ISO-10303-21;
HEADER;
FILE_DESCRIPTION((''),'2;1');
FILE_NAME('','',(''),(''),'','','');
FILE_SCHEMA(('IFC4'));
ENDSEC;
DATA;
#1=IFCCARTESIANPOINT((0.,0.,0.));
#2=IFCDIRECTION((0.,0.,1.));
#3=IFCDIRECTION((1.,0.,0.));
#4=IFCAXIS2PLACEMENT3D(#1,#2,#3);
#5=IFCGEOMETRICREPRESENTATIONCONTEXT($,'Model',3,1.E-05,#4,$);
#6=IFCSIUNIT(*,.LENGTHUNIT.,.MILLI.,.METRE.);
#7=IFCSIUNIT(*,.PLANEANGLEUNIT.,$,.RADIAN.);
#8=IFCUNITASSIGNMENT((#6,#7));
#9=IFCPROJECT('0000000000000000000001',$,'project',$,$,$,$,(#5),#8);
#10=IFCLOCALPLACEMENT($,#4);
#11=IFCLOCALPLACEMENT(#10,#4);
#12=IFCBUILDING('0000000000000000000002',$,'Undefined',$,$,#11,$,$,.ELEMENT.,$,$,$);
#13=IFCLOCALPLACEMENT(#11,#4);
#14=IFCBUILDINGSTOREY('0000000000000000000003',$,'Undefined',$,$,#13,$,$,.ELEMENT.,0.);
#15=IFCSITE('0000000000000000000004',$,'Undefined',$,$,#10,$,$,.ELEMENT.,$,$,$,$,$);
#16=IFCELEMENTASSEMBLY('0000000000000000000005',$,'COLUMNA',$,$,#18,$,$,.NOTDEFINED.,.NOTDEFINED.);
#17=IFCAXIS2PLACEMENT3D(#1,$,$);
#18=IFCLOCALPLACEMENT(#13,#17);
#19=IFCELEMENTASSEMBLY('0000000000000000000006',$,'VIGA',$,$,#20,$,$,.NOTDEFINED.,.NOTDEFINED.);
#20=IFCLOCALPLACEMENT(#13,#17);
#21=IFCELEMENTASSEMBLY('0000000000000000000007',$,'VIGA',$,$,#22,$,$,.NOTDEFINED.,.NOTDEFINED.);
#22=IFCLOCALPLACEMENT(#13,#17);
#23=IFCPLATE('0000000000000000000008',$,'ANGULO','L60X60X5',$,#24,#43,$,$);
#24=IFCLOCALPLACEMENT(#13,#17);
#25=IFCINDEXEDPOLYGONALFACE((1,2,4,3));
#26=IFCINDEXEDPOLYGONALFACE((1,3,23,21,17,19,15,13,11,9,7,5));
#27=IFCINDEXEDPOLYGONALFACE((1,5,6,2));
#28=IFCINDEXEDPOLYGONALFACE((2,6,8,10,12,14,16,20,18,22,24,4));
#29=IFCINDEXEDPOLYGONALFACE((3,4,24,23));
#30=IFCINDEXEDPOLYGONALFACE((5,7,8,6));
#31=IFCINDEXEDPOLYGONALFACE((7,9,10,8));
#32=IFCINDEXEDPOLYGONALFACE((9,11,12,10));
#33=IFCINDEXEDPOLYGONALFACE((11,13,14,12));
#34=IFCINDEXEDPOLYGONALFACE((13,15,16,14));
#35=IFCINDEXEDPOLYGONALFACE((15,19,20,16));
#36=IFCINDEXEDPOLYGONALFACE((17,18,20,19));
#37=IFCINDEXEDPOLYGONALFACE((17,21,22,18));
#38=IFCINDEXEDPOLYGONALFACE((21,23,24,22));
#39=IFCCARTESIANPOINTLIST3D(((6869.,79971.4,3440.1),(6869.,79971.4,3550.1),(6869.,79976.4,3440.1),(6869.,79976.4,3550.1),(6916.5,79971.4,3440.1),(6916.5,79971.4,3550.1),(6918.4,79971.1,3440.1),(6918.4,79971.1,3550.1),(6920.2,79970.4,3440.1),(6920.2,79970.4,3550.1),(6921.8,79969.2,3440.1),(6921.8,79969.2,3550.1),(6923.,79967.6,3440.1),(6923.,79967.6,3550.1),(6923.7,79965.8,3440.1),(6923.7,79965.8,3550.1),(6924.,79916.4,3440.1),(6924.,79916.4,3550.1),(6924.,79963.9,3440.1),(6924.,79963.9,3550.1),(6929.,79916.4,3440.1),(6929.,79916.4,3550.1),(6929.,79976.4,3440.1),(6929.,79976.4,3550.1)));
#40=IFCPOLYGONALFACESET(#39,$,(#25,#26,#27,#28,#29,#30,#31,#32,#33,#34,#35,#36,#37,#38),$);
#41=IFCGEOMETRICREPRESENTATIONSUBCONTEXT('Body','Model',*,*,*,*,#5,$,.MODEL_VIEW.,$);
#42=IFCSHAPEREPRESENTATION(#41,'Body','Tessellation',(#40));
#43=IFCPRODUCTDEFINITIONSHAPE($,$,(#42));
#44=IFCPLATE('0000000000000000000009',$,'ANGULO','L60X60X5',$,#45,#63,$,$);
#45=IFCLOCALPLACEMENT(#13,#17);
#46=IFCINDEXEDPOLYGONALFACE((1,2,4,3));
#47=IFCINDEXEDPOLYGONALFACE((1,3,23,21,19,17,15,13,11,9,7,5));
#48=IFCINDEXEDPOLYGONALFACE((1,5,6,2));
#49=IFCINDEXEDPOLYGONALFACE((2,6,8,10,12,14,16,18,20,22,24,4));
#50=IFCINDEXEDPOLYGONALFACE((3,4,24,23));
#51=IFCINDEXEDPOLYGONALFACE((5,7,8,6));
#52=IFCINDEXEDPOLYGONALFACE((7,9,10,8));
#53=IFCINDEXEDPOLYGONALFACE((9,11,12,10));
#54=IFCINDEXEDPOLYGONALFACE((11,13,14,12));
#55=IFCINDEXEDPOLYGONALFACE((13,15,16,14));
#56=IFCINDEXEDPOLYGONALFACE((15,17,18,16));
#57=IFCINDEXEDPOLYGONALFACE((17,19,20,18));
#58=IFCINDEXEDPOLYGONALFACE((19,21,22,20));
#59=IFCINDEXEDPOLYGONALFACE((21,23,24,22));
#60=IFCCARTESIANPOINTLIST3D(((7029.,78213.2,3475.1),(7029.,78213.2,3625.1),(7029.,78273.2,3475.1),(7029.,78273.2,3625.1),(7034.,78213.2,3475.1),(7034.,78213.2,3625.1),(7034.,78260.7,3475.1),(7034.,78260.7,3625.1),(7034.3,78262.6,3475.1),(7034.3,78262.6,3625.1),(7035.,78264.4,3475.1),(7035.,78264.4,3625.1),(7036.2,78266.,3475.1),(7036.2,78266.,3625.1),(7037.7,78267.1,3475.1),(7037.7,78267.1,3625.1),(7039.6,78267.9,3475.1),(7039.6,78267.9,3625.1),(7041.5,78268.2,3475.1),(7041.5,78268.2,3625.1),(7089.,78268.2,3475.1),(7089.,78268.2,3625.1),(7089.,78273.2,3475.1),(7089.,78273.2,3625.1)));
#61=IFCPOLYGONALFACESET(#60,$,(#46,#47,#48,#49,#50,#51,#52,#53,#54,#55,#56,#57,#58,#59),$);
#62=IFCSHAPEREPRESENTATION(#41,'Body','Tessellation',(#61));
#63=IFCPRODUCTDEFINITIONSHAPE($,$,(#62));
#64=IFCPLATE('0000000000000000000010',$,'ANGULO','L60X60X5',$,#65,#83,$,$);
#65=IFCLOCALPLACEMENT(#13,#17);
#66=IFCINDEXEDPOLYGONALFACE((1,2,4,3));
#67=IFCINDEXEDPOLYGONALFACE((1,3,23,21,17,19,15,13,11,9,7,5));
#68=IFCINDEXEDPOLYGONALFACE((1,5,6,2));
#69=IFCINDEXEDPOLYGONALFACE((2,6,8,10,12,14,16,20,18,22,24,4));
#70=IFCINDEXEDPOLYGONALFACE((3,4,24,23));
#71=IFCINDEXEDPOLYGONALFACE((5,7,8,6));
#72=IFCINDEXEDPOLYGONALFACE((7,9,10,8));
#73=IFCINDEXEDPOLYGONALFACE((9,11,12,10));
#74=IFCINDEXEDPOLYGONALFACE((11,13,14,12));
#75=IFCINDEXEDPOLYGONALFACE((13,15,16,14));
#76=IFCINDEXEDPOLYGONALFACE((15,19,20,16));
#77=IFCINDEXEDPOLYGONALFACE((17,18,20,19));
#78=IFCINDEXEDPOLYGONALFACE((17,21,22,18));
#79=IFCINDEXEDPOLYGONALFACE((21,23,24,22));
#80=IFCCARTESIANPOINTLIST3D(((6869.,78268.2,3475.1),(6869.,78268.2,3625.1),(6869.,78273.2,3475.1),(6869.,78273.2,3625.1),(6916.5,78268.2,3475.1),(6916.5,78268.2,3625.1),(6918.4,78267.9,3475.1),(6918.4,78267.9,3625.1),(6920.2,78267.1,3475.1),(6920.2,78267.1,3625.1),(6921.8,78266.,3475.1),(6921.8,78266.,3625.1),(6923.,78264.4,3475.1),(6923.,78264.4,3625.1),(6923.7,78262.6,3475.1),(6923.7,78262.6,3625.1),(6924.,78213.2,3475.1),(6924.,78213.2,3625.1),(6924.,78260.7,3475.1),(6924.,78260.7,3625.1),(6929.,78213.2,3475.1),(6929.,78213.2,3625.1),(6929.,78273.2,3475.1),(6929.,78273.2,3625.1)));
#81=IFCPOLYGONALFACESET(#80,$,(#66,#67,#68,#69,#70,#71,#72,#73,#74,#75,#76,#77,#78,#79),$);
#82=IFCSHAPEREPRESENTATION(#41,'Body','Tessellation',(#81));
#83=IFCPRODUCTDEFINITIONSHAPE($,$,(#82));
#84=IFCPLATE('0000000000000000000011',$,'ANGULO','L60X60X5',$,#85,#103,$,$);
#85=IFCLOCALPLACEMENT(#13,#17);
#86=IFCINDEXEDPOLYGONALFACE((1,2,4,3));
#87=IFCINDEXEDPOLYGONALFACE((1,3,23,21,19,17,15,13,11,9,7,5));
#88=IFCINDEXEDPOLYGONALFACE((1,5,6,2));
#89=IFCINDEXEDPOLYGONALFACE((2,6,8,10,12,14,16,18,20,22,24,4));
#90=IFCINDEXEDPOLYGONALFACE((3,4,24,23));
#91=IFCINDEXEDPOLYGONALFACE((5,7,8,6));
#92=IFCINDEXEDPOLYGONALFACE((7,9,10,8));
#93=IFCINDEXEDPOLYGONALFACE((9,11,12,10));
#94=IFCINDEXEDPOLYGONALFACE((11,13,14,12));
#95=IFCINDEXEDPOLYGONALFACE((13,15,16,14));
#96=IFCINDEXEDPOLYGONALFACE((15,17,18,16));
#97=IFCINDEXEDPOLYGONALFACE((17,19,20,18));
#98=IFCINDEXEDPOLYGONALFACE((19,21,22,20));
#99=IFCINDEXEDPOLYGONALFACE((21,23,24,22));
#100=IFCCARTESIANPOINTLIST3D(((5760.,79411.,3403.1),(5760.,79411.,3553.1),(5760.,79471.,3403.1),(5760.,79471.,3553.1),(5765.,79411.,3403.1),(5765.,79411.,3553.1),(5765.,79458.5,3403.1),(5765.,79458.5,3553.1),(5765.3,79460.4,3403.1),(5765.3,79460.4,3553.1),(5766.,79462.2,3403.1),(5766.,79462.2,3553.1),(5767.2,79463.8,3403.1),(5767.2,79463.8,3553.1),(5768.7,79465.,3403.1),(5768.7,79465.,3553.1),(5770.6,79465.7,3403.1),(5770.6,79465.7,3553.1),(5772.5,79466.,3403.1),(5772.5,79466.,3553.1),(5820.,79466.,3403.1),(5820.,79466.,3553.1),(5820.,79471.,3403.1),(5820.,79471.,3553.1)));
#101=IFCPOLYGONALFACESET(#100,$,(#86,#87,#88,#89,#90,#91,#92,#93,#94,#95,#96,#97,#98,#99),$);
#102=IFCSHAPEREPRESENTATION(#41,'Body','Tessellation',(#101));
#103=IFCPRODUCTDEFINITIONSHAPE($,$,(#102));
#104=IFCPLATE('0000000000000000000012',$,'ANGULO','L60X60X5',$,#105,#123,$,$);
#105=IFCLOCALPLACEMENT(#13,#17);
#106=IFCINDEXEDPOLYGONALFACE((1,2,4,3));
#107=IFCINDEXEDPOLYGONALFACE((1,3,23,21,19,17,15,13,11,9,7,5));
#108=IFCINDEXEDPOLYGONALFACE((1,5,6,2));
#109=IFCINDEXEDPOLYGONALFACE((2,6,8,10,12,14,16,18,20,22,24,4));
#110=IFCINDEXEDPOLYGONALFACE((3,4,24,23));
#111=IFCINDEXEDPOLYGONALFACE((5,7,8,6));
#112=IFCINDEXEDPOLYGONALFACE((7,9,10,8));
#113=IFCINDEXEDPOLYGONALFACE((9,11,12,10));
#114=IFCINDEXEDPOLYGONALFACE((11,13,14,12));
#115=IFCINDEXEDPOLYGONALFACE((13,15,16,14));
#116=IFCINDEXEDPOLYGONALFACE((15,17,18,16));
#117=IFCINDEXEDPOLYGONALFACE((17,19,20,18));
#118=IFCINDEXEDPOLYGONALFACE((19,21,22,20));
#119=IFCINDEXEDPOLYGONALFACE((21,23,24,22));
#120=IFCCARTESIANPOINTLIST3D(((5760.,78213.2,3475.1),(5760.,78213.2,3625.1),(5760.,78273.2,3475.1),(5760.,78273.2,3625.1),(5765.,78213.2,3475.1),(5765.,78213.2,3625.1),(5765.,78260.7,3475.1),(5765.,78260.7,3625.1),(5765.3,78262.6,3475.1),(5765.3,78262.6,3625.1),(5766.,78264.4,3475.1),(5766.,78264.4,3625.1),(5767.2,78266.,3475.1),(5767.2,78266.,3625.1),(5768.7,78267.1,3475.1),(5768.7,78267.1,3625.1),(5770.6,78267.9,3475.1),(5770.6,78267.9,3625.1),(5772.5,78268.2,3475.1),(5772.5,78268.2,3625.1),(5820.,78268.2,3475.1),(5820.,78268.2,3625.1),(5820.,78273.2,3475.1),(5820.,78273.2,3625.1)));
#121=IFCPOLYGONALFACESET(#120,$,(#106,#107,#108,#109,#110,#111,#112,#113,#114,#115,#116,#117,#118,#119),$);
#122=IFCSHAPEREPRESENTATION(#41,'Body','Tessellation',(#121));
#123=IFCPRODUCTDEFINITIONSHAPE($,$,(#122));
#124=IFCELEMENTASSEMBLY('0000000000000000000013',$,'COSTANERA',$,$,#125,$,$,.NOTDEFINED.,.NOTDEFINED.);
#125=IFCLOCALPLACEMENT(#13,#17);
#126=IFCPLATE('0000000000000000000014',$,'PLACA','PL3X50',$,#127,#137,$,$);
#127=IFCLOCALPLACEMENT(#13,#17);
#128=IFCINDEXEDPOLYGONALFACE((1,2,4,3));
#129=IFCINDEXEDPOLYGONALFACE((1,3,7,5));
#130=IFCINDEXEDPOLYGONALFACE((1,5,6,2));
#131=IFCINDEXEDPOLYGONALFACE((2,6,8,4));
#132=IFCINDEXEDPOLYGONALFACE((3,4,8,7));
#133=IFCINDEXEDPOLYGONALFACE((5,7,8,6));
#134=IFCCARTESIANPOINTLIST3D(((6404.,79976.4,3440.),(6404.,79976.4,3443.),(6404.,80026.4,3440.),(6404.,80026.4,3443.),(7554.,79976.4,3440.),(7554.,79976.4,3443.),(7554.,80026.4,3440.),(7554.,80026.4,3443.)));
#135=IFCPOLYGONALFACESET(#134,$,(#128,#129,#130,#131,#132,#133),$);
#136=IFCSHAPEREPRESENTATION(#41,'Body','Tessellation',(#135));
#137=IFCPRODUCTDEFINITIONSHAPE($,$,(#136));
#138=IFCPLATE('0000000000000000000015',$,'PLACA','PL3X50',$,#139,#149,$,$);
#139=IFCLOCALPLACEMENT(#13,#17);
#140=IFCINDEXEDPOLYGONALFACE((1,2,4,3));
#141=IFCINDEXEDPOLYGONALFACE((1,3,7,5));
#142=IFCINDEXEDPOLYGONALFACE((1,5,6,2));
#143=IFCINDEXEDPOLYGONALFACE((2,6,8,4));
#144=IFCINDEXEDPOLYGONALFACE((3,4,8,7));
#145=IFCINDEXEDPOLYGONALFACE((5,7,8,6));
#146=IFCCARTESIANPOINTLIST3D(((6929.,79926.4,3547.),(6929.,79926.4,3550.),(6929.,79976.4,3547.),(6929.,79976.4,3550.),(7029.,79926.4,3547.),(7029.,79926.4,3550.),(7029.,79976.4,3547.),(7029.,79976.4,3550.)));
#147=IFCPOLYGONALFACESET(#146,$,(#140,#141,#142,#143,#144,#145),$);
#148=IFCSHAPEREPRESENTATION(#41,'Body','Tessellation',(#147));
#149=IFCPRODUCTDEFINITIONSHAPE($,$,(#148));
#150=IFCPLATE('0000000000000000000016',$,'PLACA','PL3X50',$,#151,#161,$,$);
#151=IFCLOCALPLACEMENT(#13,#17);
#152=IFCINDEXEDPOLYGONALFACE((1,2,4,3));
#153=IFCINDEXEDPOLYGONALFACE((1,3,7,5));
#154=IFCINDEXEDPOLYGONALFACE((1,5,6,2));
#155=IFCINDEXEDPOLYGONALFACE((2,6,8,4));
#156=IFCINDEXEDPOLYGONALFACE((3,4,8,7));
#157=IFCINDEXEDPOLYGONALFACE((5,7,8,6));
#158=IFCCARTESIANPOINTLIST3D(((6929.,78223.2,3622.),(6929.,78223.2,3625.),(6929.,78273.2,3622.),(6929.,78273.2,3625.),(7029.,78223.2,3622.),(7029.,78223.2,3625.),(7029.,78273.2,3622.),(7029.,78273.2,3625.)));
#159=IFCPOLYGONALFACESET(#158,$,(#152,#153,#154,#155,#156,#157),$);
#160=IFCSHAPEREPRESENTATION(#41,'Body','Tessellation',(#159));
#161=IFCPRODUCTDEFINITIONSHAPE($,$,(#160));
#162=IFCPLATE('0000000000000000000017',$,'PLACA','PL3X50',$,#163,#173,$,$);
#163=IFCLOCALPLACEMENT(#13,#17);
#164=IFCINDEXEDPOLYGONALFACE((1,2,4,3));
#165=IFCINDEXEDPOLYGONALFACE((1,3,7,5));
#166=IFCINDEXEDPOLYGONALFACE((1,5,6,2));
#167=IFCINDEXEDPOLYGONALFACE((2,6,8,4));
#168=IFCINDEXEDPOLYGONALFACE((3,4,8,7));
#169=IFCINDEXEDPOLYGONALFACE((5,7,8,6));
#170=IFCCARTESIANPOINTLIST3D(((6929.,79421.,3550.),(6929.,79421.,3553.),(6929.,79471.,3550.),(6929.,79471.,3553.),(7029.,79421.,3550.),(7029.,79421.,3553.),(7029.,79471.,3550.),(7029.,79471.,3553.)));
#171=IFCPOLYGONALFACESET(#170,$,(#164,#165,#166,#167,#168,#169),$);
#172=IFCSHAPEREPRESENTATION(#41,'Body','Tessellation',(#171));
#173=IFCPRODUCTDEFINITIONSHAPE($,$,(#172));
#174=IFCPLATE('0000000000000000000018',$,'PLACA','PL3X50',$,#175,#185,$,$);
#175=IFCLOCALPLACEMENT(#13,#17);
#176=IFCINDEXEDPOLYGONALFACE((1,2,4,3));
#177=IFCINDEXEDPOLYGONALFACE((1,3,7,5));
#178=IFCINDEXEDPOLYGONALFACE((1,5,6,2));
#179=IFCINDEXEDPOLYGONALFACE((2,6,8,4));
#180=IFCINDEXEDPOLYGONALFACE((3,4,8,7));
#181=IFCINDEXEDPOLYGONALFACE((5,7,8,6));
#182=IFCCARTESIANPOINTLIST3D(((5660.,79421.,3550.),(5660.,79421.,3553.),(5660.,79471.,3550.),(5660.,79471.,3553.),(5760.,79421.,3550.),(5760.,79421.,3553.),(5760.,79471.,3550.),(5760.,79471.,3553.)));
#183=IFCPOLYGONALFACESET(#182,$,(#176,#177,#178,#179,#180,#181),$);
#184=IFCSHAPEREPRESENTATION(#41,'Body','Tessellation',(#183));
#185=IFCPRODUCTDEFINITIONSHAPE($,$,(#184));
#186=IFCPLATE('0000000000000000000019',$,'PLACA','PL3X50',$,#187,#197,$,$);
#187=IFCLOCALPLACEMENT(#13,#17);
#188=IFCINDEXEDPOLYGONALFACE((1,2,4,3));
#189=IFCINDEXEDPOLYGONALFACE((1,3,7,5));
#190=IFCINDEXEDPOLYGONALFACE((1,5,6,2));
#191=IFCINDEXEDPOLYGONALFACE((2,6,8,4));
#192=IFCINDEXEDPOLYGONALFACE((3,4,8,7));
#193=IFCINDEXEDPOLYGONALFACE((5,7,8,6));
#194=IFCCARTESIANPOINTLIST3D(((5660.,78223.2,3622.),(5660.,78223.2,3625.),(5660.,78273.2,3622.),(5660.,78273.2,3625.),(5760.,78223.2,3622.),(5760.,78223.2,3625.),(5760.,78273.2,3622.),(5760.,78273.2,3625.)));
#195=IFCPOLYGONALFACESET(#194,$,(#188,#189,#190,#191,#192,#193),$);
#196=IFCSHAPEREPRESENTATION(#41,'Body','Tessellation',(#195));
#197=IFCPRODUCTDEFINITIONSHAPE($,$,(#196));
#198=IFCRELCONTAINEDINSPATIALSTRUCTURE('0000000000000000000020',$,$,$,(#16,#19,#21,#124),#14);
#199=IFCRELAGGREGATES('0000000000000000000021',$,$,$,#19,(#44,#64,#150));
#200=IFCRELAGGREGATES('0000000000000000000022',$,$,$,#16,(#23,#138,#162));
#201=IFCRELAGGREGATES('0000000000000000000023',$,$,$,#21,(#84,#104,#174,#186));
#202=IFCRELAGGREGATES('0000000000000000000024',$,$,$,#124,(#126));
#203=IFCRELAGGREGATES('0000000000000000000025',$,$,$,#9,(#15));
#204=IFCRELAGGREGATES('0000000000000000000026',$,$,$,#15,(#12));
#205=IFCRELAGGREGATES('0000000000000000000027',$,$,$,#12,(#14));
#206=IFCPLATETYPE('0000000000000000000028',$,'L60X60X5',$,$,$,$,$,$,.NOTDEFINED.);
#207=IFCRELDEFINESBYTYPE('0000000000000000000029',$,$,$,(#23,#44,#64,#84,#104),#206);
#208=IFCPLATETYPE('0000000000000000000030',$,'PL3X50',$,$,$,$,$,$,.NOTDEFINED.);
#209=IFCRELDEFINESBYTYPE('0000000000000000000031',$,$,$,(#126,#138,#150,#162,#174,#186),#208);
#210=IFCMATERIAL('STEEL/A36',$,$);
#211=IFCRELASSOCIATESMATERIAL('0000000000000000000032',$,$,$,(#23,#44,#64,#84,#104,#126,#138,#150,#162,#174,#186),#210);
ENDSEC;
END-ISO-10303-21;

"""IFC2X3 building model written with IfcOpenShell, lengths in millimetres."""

from ifc_helpers import new_model, si_unit, frame, origin_with_axes, origin_2d_with_axis, place, context, subcontext, project, spatial, polyline, l_section, outline, extrude, material, type_object, element, aggregate, save


model = new_model("IFC2X3")

# Units and contexts
model_context = context("Model", 3, precision=1e-05, world=origin_with_axes())
body_context = subcontext(model_context, "Body", "Model", "MODEL_VIEW")
ifc_project = project(units=[si_unit("LENGTHUNIT", "METRE", prefix="MILLI"), si_unit("PLANEANGLEUNIT", "RADIAN")], contexts=[model_context])

# Site, building, storey
site_placement = place(None, origin_with_axes())
site = spatial("IfcSite", under=ifc_project, at=site_placement, Name="Undefined", CompositionType="ELEMENT")
building_placement = place(site_placement, origin_with_axes())
building = spatial("IfcBuilding", under=site, at=building_placement, Name="Undefined", CompositionType="ELEMENT")
storey_placement = place(building_placement, origin_with_axes())
storey = spatial("IfcBuildingStorey", under=building, at=storey_placement, Name="Undefined", CompositionType="ELEMENT", Elevation=0.0)

# Element assemblies
assembly_1_placement = place(storey_placement, origin_with_axes())
assembly_1 = element("IfcElementAssembly", 1, at=assembly_1_placement, inside=storey, Name="COLUMNA", AssemblyPlace="NOTDEFINED", PredefinedType="NOTDEFINED")
ifc_material_1 = material(Name="STEEL/A36")
assembly_2_placement = place(storey_placement, origin_with_axes())
assembly_2 = element("IfcElementAssembly", 2, at=assembly_2_placement, inside=storey, Name="VIGA", AssemblyPlace="NOTDEFINED", PredefinedType="NOTDEFINED")

# Element assembly
assembly_3_placement = place(storey_placement, origin_with_axes())
assembly_3 = element("IfcElementAssembly", 3, at=assembly_3_placement, inside=storey, Name="VIGA", AssemblyPlace="NOTDEFINED", PredefinedType="NOTDEFINED")

# Plates
plate_type_1 = type_object("IfcPlateType", Name="L60X60X5", PredefinedType="NOTDEFINED")
plate_1_placement = place(assembly_1_placement, frame((6899.0, 79946.4, 3550.1), z_axis=(0.0, -1.0, 0.0), x_axis=(0.0, 0.0, -1.0)))
plate_1 = element("IfcPlate", 4, at=plate_1_placement, type_object=plate_type_1, material=ifc_material_1, Name="ANGULO", Description="L60X60X5", context=body_context, shape_type="SweptSolid", body=[
    extrude(l_section(Depth=60.0, Width=60.0, Thickness=5.0, FilletRadius=7.5, at=origin_2d_with_axis()), frame((110.0, 0.0, 0.0), z_axis=(-1.0, 0.0, 0.0), x_axis=(0.0, -1.0, 0.0)), (0.0, 0.0, 1.0), 110.0),
])
plate_2_placement = place(assembly_2_placement, frame((7059.0, 78243.2, 3475.1), z_axis=(0.0, -1.0, 0.0), x_axis=(0.0, 0.0, 1.0)))
plate_2 = element("IfcPlate", 5, at=plate_2_placement, type_object=plate_type_1, material=ifc_material_1, Name="ANGULO", Description="L60X60X5", context=body_context, shape_type="SweptSolid", body=[
    extrude(l_section(Depth=60.0, Width=60.0, Thickness=5.0, FilletRadius=7.5, at=origin_2d_with_axis()), frame((150.0, 0.0, 0.0), z_axis=(-1.0, 0.0, 0.0), x_axis=(0.0, -1.0, 0.0)), (0.0, 0.0, 1.0), 150.0),
])
plate_3_placement = place(assembly_2_placement, frame((6899.0, 78243.2, 3625.1), z_axis=(0.0, -1.0, 0.0), x_axis=(0.0, 0.0, -1.0)))
plate_3 = element("IfcPlate", 6, at=plate_3_placement, type_object=plate_type_1, material=ifc_material_1, Name="ANGULO", Description="L60X60X5", context=body_context, shape_type="SweptSolid", body=[
    extrude(l_section(Depth=60.0, Width=60.0, Thickness=5.0, FilletRadius=7.5, at=origin_2d_with_axis()), frame((150.0, 0.0, 0.0), z_axis=(-1.0, 0.0, 0.0), x_axis=(0.0, -1.0, 0.0)), (0.0, 0.0, 1.0), 150.0),
])
plate_4_placement = place(assembly_3_placement, frame((5790.0, 79441.0, 3403.1), z_axis=(0.0, -1.0, 0.0), x_axis=(0.0, 0.0, 1.0)))
plate_4 = element("IfcPlate", 7, at=plate_4_placement, type_object=plate_type_1, material=ifc_material_1, Name="ANGULO", Description="L60X60X5", context=body_context, shape_type="SweptSolid", body=[
    extrude(l_section(Depth=60.0, Width=60.0, Thickness=5.0, FilletRadius=7.5, at=origin_2d_with_axis()), frame((150.0, 0.0, 0.0), z_axis=(-1.0, 0.0, 0.0), x_axis=(0.0, -1.0, 0.0)), (0.0, 0.0, 1.0), 150.0),
])
plate_5_placement = place(assembly_3_placement, frame((5790.0, 78243.2, 3475.1), z_axis=(0.0, -1.0, 0.0), x_axis=(0.0, 0.0, 1.0)))
plate_5 = element("IfcPlate", 8, at=plate_5_placement, type_object=plate_type_1, material=ifc_material_1, Name="ANGULO", Description="L60X60X5", context=body_context, shape_type="SweptSolid", body=[
    extrude(l_section(Depth=60.0, Width=60.0, Thickness=5.0, FilletRadius=7.5, at=origin_2d_with_axis()), frame((150.0, 0.0, 0.0), z_axis=(-1.0, 0.0, 0.0), x_axis=(0.0, -1.0, 0.0)), (0.0, 0.0, 1.0), 150.0),
])

# Element assembly, plate
assembly_4_placement = place(storey_placement, origin_with_axes())
assembly_4 = element("IfcElementAssembly", 9, at=assembly_4_placement, inside=storey, Name="COSTANERA", AssemblyPlace="NOTDEFINED", PredefinedType="NOTDEFINED")
plate_type_2 = type_object("IfcPlateType", Name="PL3X50", PredefinedType="NOTDEFINED")
plate_6_placement = place(assembly_4_placement, frame((6404.0, 79976.4, 3441.5), z_axis=(0.0, 0.0, 1.0), x_axis=(1.0, 0.0, 0.0)))
plate_6 = element("IfcPlate", 10, at=plate_6_placement, type_object=plate_type_2, material=ifc_material_1, Name="PLACA", Description="PL3X50", context=body_context, shape_type="SweptSolid", body=[
    extrude(outline(polyline([(0.0, 0.0), (1150.0, 0.0), (1150.0, 50.0), (0.0, 50.0), (0.0, 0.0)])), frame((0.0, 0.0, -1.5), z_axis=(0.0, 0.0, 1.0), x_axis=(1.0, 0.0, 0.0)), (0.0, 0.0, 1.0), 3.0),
])

# Plates
plate_7_placement = place(assembly_1_placement, frame((6929.0, 79926.4, 3548.5), z_axis=(0.0, 0.0, -1.0), x_axis=(0.0, 1.0, 0.0)))
plate_7 = element("IfcPlate", 11, at=plate_7_placement, type_object=plate_type_2, material=ifc_material_1, Name="PLACA", Description="PL3X50", context=body_context, shape_type="SweptSolid", body=[
    extrude(outline(polyline([(0.0, 0.0), (50.0, 0.0), (50.0, 100.0), (0.0, 100.0), (0.0, 0.0)])), frame((0.0, 0.0, -1.5), z_axis=(0.0, 0.0, 1.0), x_axis=(1.0, 0.0, 0.0)), (0.0, 0.0, 1.0), 3.0),
])
plate_8_placement = place(assembly_2_placement, frame((6929.0, 78223.2, 3623.5), z_axis=(0.0, 0.0, -1.0), x_axis=(0.0, 1.0, 0.0)))
plate_8 = element("IfcPlate", 12, at=plate_8_placement, type_object=plate_type_2, material=ifc_material_1, Name="PLACA", Description="PL3X50", context=body_context, shape_type="SweptSolid", body=[
    extrude(outline(polyline([(0.0, 0.0), (50.0, 0.0), (50.0, 100.0), (0.0, 100.0), (0.0, 0.0)])), frame((0.0, 0.0, -1.5), z_axis=(0.0, 0.0, 1.0), x_axis=(1.0, 0.0, 0.0)), (0.0, 0.0, 1.0), 3.0),
])
aggregate(assembly_2, [plate_2, plate_3, plate_8])
plate_9_placement = place(assembly_1_placement, frame((6929.0, 79421.0, 3551.5), z_axis=(0.0, 0.0, -1.0), x_axis=(0.0, 1.0, 0.0)))
plate_9 = element("IfcPlate", 13, at=plate_9_placement, type_object=plate_type_2, material=ifc_material_1, Name="PLACA", Description="PL3X50", context=body_context, shape_type="SweptSolid", body=[
    extrude(outline(polyline([(0.0, 0.0), (50.0, 0.0), (50.0, 100.0), (0.0, 100.0), (0.0, 0.0)])), frame((0.0, 0.0, -1.5), z_axis=(0.0, 0.0, 1.0), x_axis=(1.0, 0.0, 0.0)), (0.0, 0.0, 1.0), 3.0),
])
aggregate(assembly_1, [plate_1, plate_7, plate_9])
plate_10_placement = place(assembly_3_placement, frame((5660.0, 79421.0, 3551.5), z_axis=(0.0, 0.0, -1.0), x_axis=(0.0, 1.0, 0.0)))
plate_10 = element("IfcPlate", 14, at=plate_10_placement, type_object=plate_type_2, material=ifc_material_1, Name="PLACA", Description="PL3X50", context=body_context, shape_type="SweptSolid", body=[
    extrude(outline(polyline([(0.0, 0.0), (50.0, 0.0), (50.0, 100.0), (0.0, 100.0), (0.0, 0.0)])), frame((0.0, 0.0, -1.5), z_axis=(0.0, 0.0, 1.0), x_axis=(1.0, 0.0, 0.0)), (0.0, 0.0, 1.0), 3.0),
])
plate_11_placement = place(assembly_3_placement, frame((5660.0, 78223.2, 3623.5), z_axis=(0.0, 0.0, -1.0), x_axis=(0.0, 1.0, 0.0)))
plate_11 = element("IfcPlate", 15, at=plate_11_placement, type_object=plate_type_2, material=ifc_material_1, Name="PLACA", Description="PL3X50", context=body_context, shape_type="SweptSolid", body=[
    extrude(outline(polyline([(0.0, 0.0), (50.0, 0.0), (50.0, 100.0), (0.0, 100.0), (0.0, 0.0)])), frame((0.0, 0.0, -1.5), z_axis=(0.0, 0.0, 1.0), x_axis=(1.0, 0.0, 0.0)), (0.0, 0.0, 1.0), 3.0),
])
aggregate(assembly_3, [plate_4, plate_5, plate_10, plate_11])

aggregate(assembly_4, [plate_6])

save(model, "model.ifc")
